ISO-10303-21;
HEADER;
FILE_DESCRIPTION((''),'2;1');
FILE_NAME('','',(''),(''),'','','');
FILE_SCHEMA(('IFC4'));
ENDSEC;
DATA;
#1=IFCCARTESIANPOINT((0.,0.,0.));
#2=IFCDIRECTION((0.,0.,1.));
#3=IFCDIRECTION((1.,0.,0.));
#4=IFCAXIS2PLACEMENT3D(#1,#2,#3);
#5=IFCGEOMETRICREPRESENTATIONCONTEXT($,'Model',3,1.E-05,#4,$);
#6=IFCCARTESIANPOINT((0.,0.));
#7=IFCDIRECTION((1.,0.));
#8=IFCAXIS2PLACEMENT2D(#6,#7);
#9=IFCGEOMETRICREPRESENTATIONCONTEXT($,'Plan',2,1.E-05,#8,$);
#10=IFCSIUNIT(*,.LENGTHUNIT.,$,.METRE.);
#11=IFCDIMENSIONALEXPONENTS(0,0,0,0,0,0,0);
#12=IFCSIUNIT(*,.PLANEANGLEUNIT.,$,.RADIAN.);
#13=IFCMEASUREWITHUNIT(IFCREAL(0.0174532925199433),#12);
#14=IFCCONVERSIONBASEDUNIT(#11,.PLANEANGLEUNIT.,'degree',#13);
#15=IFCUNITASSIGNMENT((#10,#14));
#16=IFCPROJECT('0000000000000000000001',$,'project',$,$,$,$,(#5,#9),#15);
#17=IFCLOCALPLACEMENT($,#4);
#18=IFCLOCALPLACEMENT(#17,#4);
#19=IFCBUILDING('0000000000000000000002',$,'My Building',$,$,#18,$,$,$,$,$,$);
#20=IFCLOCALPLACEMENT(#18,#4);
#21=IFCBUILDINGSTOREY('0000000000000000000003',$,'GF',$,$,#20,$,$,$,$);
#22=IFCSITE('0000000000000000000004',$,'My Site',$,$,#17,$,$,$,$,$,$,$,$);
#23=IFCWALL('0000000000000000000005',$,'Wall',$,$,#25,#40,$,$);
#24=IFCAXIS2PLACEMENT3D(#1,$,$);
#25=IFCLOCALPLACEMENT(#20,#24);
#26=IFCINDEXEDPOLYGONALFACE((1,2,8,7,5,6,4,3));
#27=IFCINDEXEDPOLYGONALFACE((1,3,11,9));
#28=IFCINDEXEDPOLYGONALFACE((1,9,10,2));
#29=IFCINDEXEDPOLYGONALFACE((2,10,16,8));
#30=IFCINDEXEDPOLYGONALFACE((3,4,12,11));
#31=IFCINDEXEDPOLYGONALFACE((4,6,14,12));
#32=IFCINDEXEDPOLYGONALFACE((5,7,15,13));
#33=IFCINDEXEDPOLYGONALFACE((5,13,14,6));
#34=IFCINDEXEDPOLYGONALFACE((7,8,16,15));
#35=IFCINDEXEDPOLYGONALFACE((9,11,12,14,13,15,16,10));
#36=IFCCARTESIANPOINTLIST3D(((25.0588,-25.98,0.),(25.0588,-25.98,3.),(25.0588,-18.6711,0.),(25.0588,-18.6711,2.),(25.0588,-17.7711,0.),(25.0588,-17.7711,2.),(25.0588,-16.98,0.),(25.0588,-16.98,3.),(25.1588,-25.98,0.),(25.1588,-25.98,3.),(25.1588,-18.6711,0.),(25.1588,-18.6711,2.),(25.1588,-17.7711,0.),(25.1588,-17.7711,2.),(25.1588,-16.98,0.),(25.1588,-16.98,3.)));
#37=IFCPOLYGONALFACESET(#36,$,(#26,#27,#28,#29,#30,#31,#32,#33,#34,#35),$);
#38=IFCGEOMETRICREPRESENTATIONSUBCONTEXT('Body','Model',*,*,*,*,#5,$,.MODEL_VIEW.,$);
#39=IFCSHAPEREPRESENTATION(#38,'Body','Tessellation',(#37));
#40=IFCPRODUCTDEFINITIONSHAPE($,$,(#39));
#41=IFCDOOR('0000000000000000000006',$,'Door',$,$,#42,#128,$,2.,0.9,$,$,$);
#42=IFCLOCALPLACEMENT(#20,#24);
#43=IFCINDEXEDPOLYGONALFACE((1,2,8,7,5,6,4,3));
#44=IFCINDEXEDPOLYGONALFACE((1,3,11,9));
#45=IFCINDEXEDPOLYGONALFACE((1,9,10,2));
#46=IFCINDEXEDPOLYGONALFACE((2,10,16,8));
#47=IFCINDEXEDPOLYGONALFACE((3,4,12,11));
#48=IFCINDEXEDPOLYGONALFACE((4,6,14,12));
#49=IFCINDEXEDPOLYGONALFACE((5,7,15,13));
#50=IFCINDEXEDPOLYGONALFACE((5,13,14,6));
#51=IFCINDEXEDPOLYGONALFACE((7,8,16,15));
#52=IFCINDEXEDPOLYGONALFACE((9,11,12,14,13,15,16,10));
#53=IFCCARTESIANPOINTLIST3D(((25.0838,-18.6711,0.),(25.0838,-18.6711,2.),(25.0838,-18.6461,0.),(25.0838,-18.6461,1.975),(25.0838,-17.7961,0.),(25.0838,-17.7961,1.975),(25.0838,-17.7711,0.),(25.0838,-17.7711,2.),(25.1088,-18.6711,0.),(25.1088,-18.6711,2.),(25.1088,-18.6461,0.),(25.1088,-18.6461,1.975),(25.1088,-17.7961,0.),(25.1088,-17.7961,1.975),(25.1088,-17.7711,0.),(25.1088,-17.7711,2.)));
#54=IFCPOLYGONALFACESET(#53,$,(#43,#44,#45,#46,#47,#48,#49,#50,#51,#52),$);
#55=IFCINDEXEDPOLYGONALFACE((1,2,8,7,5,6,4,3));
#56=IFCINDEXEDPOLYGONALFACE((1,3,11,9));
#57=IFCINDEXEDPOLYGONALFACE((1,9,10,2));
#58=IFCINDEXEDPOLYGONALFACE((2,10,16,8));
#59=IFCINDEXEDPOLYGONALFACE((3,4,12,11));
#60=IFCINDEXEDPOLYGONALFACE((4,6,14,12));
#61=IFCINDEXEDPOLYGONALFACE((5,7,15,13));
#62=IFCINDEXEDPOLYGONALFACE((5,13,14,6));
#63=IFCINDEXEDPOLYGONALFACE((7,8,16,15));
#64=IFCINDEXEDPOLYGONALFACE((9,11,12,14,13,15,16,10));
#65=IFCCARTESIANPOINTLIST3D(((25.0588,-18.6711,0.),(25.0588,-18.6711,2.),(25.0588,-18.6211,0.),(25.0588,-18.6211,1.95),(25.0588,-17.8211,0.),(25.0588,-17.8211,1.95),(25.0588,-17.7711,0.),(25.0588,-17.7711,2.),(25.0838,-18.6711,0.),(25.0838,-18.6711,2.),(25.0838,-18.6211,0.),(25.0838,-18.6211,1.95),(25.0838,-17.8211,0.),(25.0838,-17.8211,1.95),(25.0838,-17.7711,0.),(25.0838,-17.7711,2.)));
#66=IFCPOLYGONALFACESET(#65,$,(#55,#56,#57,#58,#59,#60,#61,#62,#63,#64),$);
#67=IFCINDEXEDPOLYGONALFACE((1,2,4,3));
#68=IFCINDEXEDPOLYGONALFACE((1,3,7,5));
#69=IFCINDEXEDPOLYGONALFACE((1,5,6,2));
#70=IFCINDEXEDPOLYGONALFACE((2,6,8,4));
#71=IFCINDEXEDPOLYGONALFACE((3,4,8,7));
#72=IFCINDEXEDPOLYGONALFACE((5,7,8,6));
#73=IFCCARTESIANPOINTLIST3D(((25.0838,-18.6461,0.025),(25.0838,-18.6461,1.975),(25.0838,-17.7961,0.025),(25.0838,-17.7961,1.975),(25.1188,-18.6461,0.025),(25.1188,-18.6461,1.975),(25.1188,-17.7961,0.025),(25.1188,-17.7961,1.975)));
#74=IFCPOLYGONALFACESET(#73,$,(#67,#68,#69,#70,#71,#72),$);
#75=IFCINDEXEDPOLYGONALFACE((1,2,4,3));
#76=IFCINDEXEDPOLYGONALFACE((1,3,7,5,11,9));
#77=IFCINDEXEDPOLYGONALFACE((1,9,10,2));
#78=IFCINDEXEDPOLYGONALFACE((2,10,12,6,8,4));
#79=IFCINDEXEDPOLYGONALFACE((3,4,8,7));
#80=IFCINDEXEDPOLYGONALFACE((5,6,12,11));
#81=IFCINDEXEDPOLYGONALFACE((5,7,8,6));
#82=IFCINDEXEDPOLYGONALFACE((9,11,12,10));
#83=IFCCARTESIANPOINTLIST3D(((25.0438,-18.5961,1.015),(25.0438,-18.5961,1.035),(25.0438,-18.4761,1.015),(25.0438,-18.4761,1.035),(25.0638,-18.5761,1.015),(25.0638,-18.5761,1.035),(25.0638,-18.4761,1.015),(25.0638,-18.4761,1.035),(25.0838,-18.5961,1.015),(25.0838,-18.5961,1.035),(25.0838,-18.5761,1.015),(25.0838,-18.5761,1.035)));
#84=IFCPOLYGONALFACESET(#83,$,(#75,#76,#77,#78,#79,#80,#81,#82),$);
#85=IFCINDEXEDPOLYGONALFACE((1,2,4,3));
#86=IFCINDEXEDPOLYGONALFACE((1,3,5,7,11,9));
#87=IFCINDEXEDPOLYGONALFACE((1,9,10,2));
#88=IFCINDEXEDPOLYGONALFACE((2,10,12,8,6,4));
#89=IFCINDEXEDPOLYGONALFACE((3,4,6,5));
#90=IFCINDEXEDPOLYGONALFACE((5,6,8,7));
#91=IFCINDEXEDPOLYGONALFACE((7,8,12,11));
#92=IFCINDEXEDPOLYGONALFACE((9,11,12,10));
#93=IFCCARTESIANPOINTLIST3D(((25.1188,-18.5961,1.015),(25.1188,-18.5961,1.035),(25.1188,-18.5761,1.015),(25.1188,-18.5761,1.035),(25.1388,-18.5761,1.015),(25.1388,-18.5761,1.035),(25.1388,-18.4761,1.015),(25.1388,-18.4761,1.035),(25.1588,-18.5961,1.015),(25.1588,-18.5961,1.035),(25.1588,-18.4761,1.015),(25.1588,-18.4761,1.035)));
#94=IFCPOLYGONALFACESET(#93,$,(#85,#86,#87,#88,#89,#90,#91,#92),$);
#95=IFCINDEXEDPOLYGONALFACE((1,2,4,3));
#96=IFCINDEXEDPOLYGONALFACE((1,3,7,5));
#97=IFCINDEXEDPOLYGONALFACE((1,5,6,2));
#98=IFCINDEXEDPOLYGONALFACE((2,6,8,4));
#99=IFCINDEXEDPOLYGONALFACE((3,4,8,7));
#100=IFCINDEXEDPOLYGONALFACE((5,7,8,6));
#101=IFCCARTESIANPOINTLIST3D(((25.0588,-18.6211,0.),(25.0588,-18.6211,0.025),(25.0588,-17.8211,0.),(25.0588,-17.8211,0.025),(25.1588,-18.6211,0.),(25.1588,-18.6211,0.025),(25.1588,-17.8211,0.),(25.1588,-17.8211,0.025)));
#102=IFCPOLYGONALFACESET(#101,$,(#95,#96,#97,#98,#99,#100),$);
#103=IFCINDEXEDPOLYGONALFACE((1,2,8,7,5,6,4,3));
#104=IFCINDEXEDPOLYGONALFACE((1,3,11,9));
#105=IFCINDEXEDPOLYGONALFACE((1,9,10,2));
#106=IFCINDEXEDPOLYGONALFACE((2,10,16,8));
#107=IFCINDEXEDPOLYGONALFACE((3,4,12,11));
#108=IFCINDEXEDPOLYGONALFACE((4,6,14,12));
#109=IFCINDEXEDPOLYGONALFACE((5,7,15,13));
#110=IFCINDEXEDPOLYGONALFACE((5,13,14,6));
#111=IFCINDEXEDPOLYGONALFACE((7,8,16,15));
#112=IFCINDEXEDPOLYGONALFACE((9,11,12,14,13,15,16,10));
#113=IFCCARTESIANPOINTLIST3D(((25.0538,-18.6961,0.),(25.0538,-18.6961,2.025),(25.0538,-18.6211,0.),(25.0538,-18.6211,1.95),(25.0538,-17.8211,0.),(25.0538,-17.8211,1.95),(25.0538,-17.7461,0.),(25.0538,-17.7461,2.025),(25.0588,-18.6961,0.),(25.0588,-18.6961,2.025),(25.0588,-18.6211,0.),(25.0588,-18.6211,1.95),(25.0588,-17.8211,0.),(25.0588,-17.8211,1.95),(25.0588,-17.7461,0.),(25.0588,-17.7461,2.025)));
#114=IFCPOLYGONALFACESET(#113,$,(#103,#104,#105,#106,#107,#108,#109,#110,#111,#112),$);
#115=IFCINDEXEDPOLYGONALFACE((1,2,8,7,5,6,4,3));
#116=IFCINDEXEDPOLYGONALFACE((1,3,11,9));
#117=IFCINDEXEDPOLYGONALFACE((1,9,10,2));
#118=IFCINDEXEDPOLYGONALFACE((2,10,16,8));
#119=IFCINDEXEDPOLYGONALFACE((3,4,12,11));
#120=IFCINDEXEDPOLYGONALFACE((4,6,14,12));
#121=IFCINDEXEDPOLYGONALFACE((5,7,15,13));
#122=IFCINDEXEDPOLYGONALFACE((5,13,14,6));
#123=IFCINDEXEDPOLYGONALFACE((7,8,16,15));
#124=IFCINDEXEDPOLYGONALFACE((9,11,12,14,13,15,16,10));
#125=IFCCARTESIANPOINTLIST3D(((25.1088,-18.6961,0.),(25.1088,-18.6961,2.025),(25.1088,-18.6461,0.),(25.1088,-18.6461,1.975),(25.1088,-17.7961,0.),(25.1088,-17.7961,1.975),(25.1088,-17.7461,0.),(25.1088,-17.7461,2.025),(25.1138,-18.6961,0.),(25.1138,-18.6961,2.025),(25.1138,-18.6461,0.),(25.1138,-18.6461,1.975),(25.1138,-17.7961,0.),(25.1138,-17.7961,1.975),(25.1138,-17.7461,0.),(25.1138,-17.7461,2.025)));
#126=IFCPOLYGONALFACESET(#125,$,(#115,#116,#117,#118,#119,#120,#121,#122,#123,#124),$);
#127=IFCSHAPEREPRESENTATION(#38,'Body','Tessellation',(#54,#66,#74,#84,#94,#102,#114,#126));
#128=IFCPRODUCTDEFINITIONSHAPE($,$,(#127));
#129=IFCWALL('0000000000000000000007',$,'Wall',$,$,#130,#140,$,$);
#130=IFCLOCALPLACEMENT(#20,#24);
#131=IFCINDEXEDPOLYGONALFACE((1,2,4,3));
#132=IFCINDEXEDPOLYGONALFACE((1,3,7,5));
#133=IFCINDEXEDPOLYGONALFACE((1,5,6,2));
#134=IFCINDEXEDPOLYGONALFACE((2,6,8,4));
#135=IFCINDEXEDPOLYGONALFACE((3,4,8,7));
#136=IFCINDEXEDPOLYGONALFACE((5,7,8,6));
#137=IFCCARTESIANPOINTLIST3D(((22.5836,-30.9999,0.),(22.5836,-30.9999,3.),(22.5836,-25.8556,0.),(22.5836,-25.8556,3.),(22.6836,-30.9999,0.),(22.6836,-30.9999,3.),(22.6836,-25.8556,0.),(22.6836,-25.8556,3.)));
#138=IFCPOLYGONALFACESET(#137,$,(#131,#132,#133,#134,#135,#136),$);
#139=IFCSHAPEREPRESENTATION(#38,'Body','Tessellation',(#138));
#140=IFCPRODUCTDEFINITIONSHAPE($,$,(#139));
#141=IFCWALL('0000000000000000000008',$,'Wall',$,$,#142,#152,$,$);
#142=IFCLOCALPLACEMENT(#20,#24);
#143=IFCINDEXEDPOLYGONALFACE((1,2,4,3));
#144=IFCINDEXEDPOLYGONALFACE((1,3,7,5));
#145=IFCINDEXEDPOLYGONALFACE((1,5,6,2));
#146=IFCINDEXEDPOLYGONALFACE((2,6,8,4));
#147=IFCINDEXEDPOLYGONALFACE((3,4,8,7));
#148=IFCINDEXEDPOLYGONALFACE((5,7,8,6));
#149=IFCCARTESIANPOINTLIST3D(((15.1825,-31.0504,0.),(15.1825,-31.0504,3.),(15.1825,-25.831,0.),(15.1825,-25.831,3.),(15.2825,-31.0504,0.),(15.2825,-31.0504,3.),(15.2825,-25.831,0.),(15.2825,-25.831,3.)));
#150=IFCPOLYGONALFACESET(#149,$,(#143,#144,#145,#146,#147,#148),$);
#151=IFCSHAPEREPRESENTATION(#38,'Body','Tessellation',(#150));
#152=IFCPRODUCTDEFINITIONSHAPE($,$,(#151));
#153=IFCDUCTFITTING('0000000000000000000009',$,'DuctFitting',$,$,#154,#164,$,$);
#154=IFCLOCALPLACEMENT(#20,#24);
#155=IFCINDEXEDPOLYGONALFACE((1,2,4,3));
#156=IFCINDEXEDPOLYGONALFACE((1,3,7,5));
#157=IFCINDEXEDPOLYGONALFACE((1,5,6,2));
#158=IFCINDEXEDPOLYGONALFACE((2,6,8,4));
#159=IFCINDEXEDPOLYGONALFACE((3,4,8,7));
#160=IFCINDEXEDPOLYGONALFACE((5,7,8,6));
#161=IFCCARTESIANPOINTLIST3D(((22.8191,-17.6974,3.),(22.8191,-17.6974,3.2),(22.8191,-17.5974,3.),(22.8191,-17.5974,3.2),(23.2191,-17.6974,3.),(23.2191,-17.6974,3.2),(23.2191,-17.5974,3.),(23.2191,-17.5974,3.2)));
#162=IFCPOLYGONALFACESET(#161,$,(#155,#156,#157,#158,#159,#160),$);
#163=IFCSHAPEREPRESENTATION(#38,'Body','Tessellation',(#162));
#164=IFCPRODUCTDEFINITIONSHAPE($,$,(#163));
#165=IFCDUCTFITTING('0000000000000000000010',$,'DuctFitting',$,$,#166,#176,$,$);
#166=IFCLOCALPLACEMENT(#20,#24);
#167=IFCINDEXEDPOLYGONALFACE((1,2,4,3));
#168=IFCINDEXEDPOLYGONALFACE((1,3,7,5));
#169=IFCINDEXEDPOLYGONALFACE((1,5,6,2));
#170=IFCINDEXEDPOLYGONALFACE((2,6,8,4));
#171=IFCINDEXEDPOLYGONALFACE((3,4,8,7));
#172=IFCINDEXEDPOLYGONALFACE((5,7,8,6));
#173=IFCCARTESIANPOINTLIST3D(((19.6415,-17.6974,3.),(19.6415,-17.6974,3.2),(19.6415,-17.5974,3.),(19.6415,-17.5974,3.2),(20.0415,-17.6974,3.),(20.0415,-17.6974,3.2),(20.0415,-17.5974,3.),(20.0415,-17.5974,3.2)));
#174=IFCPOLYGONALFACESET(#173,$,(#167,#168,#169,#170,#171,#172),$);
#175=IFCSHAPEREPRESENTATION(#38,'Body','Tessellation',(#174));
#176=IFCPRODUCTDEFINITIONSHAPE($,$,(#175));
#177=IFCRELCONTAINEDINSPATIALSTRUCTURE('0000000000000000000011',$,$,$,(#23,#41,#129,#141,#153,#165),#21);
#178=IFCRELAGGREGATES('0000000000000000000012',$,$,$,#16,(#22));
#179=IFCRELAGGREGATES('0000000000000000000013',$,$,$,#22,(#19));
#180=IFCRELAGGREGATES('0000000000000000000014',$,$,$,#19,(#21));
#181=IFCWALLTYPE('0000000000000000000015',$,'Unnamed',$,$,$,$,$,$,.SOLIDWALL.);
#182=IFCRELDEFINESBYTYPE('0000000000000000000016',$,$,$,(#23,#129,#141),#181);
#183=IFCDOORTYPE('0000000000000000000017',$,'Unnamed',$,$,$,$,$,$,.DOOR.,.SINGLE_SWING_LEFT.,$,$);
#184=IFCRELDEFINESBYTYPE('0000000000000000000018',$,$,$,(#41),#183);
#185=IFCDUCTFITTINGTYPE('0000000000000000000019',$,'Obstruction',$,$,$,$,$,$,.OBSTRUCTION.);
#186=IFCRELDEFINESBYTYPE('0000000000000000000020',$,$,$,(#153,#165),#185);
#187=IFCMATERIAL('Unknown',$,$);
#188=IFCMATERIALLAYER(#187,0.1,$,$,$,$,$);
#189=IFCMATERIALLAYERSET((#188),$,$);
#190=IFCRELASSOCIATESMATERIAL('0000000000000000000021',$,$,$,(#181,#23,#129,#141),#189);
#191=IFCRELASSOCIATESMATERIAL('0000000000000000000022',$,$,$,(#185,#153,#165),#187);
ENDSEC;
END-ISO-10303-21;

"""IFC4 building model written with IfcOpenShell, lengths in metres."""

from ifc_helpers import new_model, entity, si_unit, converted_unit, frame, origin_with_axes, origin_2d_with_axis, place, context, subcontext, project, spatial, line, indexed_curve, rectangle, outline, extrude, shape, source, transform, mapped, material, layer, layer_set, layer_usage, material_profile, profile_set, profile_usage, type_object, type_shapes, element, fill, save


model = new_model("IFC4")

# Units and contexts
model_context = context("Model", 3, precision=1e-05, world=origin_with_axes())
plan_context = context("Plan", 2, precision=1e-05, world=origin_2d_with_axis())
body_context_1 = subcontext(model_context, "Body", "Model", "MODEL_VIEW")
body_context_2 = subcontext(plan_context, "Body", "Plan", "PLAN_VIEW")
ifc_project = project(units=[si_unit("LENGTHUNIT", "METRE"), converted_unit("PLANEANGLEUNIT", "degree", entity("IfcReal", 0.0174532925199433), si_unit("PLANEANGLEUNIT", "RADIAN"), dimensions=[0, 0, 0, 0, 0, 0, 0])], contexts=[model_context, plan_context])

# Site, building, storey
site_placement = place(None, origin_with_axes())
site = spatial("IfcSite", under=ifc_project, at=site_placement, Name="My Site")
building_placement = place(site_placement, origin_with_axes())
building = spatial("IfcBuilding", under=site, at=building_placement, Name="My Building")
storey_placement = place(building_placement, origin_with_axes())
storey = spatial("IfcBuildingStorey", under=building, at=storey_placement, Name="GF")

# Shared definitions
ifc_material = material(Name="Unknown")
ifc_layer = layer(ifc_material, 0.1)
ifc_layer_set = layer_set([ifc_layer])
wall_type = type_object("IfcWallType", Name="Unnamed", PredefinedType="SOLIDWALL", material=ifc_layer_set)

# Shared definitions
shared_shape_1 = source(origin_with_axes(), body_context_1, "Body", "SweptSolid", [
    extrude(outline(indexed_curve([(0.0, 0.0), (0.9, 0.0), (0.9, 2.0), (0.0, 2.0)], segments=[line(1, 2, 3, 4, 1)])), frame((0.0, -0.6, 0.0), z_axis=(0.0, -1.0, 0.0), x_axis=(1.0, 0.0, 0.0)), (0.0, 0.0, -1.0), 1.2),
])
door_type = type_object("IfcDoorType", Name="Unnamed", OperationType="SINGLE_SWING_LEFT", PredefinedType="DOOR")
shared_shape_2 = source(origin_with_axes(), body_context_1, "Body", "SweptSolid", [
    extrude(outline(indexed_curve([(0.0, 0.0), (0.0, 2.0), (0.9, 2.0), (0.9, 0.0), (0.875, 0.0), (0.875, 1.975), (0.025, 1.975), (0.025, 0.0)], segments=[line(1, 2, 3, 4, 5, 6, 7, 8, 1)])), frame((0.0, 0.025, 0.0), z_axis=(0.0, -1.0, 0.0), x_axis=(1.0, 0.0, 0.0)), (0.0, 0.0, -1.0), 0.025),
    extrude(outline(indexed_curve([(0.0, 0.0), (0.0, 2.0), (0.9, 2.0), (0.9, 0.0), (0.85, 0.0), (0.85, 1.95), (0.05, 1.95), (0.05, 0.0)], segments=[line(1, 2, 3, 4, 5, 6, 7, 8, 1)])), frame((0.0, 0.0, 0.0), z_axis=(0.0, -1.0, 0.0), x_axis=(1.0, 0.0, 0.0)), (0.0, 0.0, -1.0), 0.025),
    extrude(outline(indexed_curve([(0.0, 0.0), (0.85, 0.0), (0.85, 0.035), (0.0, 0.035)], segments=[line(1, 2, 3, 4, 1)])), frame((0.025, 0.025, 0.025), z_axis=(0.0, 0.0, 1.0), x_axis=(1.0, 0.0, 0.0)), (0.0, 0.0, 1.0), 1.95),
    extrude(outline(indexed_curve([(0.0, 0.0), (0.0, -0.04), (-0.12, -0.04), (-0.12, -0.02), (-0.02, -0.02), (-0.02, 0.0)], segments=[line(1, 2, 3, 4, 5, 6, 1)])), frame((0.825, 0.025, 1.015), z_axis=(0.0, 0.0, 1.0), x_axis=(1.0, 0.0, 0.0)), (0.0, 0.0, 1.0), 0.02),
    extrude(outline(indexed_curve([(0.0, 0.0), (0.0, 0.04), (-0.12, 0.04), (-0.12, 0.02), (-0.02, 0.02), (-0.02, 0.0)], segments=[line(1, 2, 3, 4, 5, 6, 1)])), frame((0.825, 0.06, 1.015), z_axis=(0.0, 0.0, 1.0), x_axis=(1.0, 0.0, 0.0)), (0.0, 0.0, 1.0), 0.02),
    extrude(outline(indexed_curve([(0.0, 0.0), (0.8, 0.0), (0.8, 0.1), (0.0, 0.1)], segments=[line(1, 2, 3, 4, 1)])), frame((0.05, 0.0, 0.0), z_axis=(0.0, 0.0, 1.0), x_axis=(1.0, 0.0, 0.0)), (0.0, 0.0, 1.0), 0.025),
    extrude(outline(indexed_curve([(0.0, 0.0), (0.0, 2.025), (0.95, 2.025), (0.95, 0.0), (0.875, 0.0), (0.875, 1.95), (0.075, 1.95), (0.075, 0.0)], segments=[line(1, 2, 3, 4, 5, 6, 7, 8, 1)])), frame((-0.025, -0.005, 0.0), z_axis=(0.0, -1.0, 0.0), x_axis=(1.0, 0.0, 0.0)), (0.0, 0.0, -1.0), 0.005),
    extrude(outline(indexed_curve([(0.0, 0.0), (0.0, 2.025), (0.95, 2.025), (0.95, 0.0), (0.9, 0.0), (0.9, 1.975), (0.05, 1.975), (0.05, 0.0)], segments=[line(1, 2, 3, 4, 5, 6, 7, 8, 1)])), frame((-0.025, 0.05, 0.0), z_axis=(0.0, -1.0, 0.0), x_axis=(1.0, 0.0, 0.0)), (0.0, 0.0, -1.0), 0.005),
])
shared_shape_3 = source(origin_with_axes(), body_context_2, "Body", "Curve2D", [
    entity("IfcIndexedPolyCurve", entity("IfcCartesianPointList2D", [[0.0, 0.0], [0.0, 0.05], [0.025, 0.05], [0.025, 0.025], [0.05, 0.025], [0.05, 0.0]]), [entity("IfcLineIndex", [1, 2, 3, 4, 5, 6, 1])]),
    entity("IfcIndexedPolyCurve", entity("IfcCartesianPointList2D", [[0.9, 0.0], [0.9, 0.05], [0.875, 0.05], [0.875, 0.025], [0.85, 0.025], [0.85, 0.0]]), [entity("IfcLineIndex", [1, 2, 3, 4, 5, 6, 1])]),
    entity("IfcTrimmedCurve", entity("IfcEllipse", entity("IfcAxis2Placement2D", entity("IfcCartesianPoint", [0.06, 0.05]), entity("IfcDirection", [1.0, 0.0])), 0.815, 0.85), [entity("IfcCartesianPoint", [0.875, 0.05])], [entity("IfcCartesianPoint", [0.06, 0.9])], True, "CARTESIAN"),
    entity("IfcIndexedPolyCurve", entity("IfcCartesianPointList2D", [[0.025, 0.05], [0.06, 0.05], [0.06, 0.9], [0.025, 0.9]]), [entity("IfcLineIndex", [1, 2, 3, 4, 1])]),
])
type_shapes(door_type, [shared_shape_2, shared_shape_3])

# Wall, opening, door
ifc_layer_usage_1 = layer_usage(ifc_layer_set, "AXIS2", "POSITIVE", 0.0)
wall_1_placement = place(storey_placement, frame((25.0588, -16.98, 0.0), z_axis=(0.0, 0.0, 1.0), x_axis=(0.0, -1.0, 0.0)))
wall_1 = element("IfcWall", 1, at=wall_1_placement, inside=storey, type_object=wall_type, material=ifc_layer_usage_1, Name="Wall", context=body_context_1, shape_type="SweptSolid", body=[
    extrude(outline(indexed_curve([(0.0, 0.0), (0.0, 0.1), (9.0, 0.1), (9.0, 0.0)], segments=[line(1, 2, 3, 4, 1)])), origin_with_axes(), (0.0, 0.0, 1.0), 3.0),
])
opening_1_placement = place(wall_1_placement, frame((0.7911, 0.0, 0.0), z_axis=(0.0, 0.0, 1.0), x_axis=(1.0, 0.0, 0.0)))
opening_1 = element("IfcOpeningElement", 2, at=opening_1_placement, cuts=wall_1, PredefinedType="OPENING", context=body_context_1, shape_type="MappedRepresentation", body=[
    mapped(shared_shape_1, transform((0.0, 0.0, 0.0), x_axis=(1.0, 0.0, 0.0), y_axis=(0.0, 1.0, 0.0), z_axis=(0.0, 0.0, 1.0), scale=1.0)),
])
door_1_placement = place(opening_1_placement, frame((0.0, 0.0, 0.0), z_axis=(0.0, 0.0, 1.0), x_axis=(1.0, 0.0, 0.0)))
door_1 = element("IfcDoor", 3, at=door_1_placement, inside=storey, type_object=door_type, Name="Door", OverallHeight=2.0, OverallWidth=0.9, shapes=[
    shape(body_context_1, "Body", "MappedRepresentation", [mapped(shared_shape_2, transform((0.0, 0.0, 0.0), x_axis=(1.0, 0.0, 0.0), y_axis=(0.0, 1.0, 0.0), z_axis=(0.0, 0.0, 1.0), scale=1.0))]),
    shape(body_context_2, "Body", "MappedRepresentation", [mapped(shared_shape_3, transform((0.0, 0.0, 0.0), x_axis=(1.0, 0.0, 0.0), y_axis=(0.0, 1.0, 0.0), z_axis=(0.0, 0.0, 1.0), scale=1.0))]),
])
fill(opening_1, door_1)

# Walls
ifc_layer_usage_2 = layer_usage(ifc_layer_set, "AXIS2", "POSITIVE", 0.0)
wall_2_placement = place(storey_placement, frame((22.5836, -25.8556, 0.0), z_axis=(0.0, 0.0, 1.0), x_axis=(0.0, -1.0, 0.0)))
element("IfcWall", 4, at=wall_2_placement, inside=storey, type_object=wall_type, material=ifc_layer_usage_2, Name="Wall", context=body_context_1, shape_type="SweptSolid", body=[
    extrude(outline(indexed_curve([(0.0, 0.0), (0.0, 0.1), (5.1443, 0.1), (5.1443, 0.0)], segments=[line(1, 2, 3, 4, 1)])), origin_with_axes(), (0.0, 0.0, 1.0), 3.0),
])
ifc_layer_usage_3 = layer_usage(ifc_layer_set, "AXIS2", "POSITIVE", 0.0)
wall_3_placement = place(storey_placement, frame((15.1825, -25.831, 0.0), z_axis=(0.0, 0.0, 1.0), x_axis=(0.0, -1.0, 0.0)))
element("IfcWall", 5, at=wall_3_placement, inside=storey, type_object=wall_type, material=ifc_layer_usage_3, Name="Wall", context=body_context_1, shape_type="SweptSolid", body=[
    extrude(outline(indexed_curve([(0.0, 0.0), (0.0, 0.1), (5.2194, 0.1), (5.2194, 0.0)], segments=[line(1, 2, 3, 4, 1)])), origin_with_axes(), (0.0, 0.0, 1.0), 3.0),
])

# Duct fittings
ifc_material_profile = material_profile(ifc_material, rectangle(XDim=0.4, YDim=0.2))
ifc_profile_set = profile_set([ifc_material_profile])
ifc_profile_usage_1 = profile_usage(ifc_profile_set, cardinal=5)
duct_fitting_type = type_object("IfcDuctFittingType", Name="Obstruction", PredefinedType="OBSTRUCTION", material=ifc_profile_set)
duct_fitting_1_placement = place(storey_placement, frame((23.0191, -17.6974, 3.1), z_axis=(0.0, 1.0, -0.000003), x_axis=(-1.0, 0.0, 0.0)))
element("IfcDuctFitting", 6, at=duct_fitting_1_placement, inside=storey, type_object=duct_fitting_type, material=ifc_profile_usage_1, Name="DuctFitting", context=body_context_1, shape_type="SweptSolid", body=[
    extrude(rectangle(XDim=0.4, YDim=0.2), origin_with_axes(), (0.0, 0.0, 1.0), 0.1),
])
ifc_profile_usage_2 = profile_usage(ifc_profile_set, cardinal=5)
duct_fitting_2_placement = place(storey_placement, frame((19.8415, -17.6974, 3.1), z_axis=(0.0, 1.0, -0.000003), x_axis=(-1.0, 0.0, 0.0)))
element("IfcDuctFitting", 7, at=duct_fitting_2_placement, inside=storey, type_object=duct_fitting_type, material=ifc_profile_usage_2, Name="DuctFitting", context=body_context_1, shape_type="SweptSolid", body=[
    extrude(rectangle(XDim=0.4, YDim=0.2), origin_with_axes(), (0.0, 0.0, 1.0), 0.1),
])

save(model, "model.ifc")
